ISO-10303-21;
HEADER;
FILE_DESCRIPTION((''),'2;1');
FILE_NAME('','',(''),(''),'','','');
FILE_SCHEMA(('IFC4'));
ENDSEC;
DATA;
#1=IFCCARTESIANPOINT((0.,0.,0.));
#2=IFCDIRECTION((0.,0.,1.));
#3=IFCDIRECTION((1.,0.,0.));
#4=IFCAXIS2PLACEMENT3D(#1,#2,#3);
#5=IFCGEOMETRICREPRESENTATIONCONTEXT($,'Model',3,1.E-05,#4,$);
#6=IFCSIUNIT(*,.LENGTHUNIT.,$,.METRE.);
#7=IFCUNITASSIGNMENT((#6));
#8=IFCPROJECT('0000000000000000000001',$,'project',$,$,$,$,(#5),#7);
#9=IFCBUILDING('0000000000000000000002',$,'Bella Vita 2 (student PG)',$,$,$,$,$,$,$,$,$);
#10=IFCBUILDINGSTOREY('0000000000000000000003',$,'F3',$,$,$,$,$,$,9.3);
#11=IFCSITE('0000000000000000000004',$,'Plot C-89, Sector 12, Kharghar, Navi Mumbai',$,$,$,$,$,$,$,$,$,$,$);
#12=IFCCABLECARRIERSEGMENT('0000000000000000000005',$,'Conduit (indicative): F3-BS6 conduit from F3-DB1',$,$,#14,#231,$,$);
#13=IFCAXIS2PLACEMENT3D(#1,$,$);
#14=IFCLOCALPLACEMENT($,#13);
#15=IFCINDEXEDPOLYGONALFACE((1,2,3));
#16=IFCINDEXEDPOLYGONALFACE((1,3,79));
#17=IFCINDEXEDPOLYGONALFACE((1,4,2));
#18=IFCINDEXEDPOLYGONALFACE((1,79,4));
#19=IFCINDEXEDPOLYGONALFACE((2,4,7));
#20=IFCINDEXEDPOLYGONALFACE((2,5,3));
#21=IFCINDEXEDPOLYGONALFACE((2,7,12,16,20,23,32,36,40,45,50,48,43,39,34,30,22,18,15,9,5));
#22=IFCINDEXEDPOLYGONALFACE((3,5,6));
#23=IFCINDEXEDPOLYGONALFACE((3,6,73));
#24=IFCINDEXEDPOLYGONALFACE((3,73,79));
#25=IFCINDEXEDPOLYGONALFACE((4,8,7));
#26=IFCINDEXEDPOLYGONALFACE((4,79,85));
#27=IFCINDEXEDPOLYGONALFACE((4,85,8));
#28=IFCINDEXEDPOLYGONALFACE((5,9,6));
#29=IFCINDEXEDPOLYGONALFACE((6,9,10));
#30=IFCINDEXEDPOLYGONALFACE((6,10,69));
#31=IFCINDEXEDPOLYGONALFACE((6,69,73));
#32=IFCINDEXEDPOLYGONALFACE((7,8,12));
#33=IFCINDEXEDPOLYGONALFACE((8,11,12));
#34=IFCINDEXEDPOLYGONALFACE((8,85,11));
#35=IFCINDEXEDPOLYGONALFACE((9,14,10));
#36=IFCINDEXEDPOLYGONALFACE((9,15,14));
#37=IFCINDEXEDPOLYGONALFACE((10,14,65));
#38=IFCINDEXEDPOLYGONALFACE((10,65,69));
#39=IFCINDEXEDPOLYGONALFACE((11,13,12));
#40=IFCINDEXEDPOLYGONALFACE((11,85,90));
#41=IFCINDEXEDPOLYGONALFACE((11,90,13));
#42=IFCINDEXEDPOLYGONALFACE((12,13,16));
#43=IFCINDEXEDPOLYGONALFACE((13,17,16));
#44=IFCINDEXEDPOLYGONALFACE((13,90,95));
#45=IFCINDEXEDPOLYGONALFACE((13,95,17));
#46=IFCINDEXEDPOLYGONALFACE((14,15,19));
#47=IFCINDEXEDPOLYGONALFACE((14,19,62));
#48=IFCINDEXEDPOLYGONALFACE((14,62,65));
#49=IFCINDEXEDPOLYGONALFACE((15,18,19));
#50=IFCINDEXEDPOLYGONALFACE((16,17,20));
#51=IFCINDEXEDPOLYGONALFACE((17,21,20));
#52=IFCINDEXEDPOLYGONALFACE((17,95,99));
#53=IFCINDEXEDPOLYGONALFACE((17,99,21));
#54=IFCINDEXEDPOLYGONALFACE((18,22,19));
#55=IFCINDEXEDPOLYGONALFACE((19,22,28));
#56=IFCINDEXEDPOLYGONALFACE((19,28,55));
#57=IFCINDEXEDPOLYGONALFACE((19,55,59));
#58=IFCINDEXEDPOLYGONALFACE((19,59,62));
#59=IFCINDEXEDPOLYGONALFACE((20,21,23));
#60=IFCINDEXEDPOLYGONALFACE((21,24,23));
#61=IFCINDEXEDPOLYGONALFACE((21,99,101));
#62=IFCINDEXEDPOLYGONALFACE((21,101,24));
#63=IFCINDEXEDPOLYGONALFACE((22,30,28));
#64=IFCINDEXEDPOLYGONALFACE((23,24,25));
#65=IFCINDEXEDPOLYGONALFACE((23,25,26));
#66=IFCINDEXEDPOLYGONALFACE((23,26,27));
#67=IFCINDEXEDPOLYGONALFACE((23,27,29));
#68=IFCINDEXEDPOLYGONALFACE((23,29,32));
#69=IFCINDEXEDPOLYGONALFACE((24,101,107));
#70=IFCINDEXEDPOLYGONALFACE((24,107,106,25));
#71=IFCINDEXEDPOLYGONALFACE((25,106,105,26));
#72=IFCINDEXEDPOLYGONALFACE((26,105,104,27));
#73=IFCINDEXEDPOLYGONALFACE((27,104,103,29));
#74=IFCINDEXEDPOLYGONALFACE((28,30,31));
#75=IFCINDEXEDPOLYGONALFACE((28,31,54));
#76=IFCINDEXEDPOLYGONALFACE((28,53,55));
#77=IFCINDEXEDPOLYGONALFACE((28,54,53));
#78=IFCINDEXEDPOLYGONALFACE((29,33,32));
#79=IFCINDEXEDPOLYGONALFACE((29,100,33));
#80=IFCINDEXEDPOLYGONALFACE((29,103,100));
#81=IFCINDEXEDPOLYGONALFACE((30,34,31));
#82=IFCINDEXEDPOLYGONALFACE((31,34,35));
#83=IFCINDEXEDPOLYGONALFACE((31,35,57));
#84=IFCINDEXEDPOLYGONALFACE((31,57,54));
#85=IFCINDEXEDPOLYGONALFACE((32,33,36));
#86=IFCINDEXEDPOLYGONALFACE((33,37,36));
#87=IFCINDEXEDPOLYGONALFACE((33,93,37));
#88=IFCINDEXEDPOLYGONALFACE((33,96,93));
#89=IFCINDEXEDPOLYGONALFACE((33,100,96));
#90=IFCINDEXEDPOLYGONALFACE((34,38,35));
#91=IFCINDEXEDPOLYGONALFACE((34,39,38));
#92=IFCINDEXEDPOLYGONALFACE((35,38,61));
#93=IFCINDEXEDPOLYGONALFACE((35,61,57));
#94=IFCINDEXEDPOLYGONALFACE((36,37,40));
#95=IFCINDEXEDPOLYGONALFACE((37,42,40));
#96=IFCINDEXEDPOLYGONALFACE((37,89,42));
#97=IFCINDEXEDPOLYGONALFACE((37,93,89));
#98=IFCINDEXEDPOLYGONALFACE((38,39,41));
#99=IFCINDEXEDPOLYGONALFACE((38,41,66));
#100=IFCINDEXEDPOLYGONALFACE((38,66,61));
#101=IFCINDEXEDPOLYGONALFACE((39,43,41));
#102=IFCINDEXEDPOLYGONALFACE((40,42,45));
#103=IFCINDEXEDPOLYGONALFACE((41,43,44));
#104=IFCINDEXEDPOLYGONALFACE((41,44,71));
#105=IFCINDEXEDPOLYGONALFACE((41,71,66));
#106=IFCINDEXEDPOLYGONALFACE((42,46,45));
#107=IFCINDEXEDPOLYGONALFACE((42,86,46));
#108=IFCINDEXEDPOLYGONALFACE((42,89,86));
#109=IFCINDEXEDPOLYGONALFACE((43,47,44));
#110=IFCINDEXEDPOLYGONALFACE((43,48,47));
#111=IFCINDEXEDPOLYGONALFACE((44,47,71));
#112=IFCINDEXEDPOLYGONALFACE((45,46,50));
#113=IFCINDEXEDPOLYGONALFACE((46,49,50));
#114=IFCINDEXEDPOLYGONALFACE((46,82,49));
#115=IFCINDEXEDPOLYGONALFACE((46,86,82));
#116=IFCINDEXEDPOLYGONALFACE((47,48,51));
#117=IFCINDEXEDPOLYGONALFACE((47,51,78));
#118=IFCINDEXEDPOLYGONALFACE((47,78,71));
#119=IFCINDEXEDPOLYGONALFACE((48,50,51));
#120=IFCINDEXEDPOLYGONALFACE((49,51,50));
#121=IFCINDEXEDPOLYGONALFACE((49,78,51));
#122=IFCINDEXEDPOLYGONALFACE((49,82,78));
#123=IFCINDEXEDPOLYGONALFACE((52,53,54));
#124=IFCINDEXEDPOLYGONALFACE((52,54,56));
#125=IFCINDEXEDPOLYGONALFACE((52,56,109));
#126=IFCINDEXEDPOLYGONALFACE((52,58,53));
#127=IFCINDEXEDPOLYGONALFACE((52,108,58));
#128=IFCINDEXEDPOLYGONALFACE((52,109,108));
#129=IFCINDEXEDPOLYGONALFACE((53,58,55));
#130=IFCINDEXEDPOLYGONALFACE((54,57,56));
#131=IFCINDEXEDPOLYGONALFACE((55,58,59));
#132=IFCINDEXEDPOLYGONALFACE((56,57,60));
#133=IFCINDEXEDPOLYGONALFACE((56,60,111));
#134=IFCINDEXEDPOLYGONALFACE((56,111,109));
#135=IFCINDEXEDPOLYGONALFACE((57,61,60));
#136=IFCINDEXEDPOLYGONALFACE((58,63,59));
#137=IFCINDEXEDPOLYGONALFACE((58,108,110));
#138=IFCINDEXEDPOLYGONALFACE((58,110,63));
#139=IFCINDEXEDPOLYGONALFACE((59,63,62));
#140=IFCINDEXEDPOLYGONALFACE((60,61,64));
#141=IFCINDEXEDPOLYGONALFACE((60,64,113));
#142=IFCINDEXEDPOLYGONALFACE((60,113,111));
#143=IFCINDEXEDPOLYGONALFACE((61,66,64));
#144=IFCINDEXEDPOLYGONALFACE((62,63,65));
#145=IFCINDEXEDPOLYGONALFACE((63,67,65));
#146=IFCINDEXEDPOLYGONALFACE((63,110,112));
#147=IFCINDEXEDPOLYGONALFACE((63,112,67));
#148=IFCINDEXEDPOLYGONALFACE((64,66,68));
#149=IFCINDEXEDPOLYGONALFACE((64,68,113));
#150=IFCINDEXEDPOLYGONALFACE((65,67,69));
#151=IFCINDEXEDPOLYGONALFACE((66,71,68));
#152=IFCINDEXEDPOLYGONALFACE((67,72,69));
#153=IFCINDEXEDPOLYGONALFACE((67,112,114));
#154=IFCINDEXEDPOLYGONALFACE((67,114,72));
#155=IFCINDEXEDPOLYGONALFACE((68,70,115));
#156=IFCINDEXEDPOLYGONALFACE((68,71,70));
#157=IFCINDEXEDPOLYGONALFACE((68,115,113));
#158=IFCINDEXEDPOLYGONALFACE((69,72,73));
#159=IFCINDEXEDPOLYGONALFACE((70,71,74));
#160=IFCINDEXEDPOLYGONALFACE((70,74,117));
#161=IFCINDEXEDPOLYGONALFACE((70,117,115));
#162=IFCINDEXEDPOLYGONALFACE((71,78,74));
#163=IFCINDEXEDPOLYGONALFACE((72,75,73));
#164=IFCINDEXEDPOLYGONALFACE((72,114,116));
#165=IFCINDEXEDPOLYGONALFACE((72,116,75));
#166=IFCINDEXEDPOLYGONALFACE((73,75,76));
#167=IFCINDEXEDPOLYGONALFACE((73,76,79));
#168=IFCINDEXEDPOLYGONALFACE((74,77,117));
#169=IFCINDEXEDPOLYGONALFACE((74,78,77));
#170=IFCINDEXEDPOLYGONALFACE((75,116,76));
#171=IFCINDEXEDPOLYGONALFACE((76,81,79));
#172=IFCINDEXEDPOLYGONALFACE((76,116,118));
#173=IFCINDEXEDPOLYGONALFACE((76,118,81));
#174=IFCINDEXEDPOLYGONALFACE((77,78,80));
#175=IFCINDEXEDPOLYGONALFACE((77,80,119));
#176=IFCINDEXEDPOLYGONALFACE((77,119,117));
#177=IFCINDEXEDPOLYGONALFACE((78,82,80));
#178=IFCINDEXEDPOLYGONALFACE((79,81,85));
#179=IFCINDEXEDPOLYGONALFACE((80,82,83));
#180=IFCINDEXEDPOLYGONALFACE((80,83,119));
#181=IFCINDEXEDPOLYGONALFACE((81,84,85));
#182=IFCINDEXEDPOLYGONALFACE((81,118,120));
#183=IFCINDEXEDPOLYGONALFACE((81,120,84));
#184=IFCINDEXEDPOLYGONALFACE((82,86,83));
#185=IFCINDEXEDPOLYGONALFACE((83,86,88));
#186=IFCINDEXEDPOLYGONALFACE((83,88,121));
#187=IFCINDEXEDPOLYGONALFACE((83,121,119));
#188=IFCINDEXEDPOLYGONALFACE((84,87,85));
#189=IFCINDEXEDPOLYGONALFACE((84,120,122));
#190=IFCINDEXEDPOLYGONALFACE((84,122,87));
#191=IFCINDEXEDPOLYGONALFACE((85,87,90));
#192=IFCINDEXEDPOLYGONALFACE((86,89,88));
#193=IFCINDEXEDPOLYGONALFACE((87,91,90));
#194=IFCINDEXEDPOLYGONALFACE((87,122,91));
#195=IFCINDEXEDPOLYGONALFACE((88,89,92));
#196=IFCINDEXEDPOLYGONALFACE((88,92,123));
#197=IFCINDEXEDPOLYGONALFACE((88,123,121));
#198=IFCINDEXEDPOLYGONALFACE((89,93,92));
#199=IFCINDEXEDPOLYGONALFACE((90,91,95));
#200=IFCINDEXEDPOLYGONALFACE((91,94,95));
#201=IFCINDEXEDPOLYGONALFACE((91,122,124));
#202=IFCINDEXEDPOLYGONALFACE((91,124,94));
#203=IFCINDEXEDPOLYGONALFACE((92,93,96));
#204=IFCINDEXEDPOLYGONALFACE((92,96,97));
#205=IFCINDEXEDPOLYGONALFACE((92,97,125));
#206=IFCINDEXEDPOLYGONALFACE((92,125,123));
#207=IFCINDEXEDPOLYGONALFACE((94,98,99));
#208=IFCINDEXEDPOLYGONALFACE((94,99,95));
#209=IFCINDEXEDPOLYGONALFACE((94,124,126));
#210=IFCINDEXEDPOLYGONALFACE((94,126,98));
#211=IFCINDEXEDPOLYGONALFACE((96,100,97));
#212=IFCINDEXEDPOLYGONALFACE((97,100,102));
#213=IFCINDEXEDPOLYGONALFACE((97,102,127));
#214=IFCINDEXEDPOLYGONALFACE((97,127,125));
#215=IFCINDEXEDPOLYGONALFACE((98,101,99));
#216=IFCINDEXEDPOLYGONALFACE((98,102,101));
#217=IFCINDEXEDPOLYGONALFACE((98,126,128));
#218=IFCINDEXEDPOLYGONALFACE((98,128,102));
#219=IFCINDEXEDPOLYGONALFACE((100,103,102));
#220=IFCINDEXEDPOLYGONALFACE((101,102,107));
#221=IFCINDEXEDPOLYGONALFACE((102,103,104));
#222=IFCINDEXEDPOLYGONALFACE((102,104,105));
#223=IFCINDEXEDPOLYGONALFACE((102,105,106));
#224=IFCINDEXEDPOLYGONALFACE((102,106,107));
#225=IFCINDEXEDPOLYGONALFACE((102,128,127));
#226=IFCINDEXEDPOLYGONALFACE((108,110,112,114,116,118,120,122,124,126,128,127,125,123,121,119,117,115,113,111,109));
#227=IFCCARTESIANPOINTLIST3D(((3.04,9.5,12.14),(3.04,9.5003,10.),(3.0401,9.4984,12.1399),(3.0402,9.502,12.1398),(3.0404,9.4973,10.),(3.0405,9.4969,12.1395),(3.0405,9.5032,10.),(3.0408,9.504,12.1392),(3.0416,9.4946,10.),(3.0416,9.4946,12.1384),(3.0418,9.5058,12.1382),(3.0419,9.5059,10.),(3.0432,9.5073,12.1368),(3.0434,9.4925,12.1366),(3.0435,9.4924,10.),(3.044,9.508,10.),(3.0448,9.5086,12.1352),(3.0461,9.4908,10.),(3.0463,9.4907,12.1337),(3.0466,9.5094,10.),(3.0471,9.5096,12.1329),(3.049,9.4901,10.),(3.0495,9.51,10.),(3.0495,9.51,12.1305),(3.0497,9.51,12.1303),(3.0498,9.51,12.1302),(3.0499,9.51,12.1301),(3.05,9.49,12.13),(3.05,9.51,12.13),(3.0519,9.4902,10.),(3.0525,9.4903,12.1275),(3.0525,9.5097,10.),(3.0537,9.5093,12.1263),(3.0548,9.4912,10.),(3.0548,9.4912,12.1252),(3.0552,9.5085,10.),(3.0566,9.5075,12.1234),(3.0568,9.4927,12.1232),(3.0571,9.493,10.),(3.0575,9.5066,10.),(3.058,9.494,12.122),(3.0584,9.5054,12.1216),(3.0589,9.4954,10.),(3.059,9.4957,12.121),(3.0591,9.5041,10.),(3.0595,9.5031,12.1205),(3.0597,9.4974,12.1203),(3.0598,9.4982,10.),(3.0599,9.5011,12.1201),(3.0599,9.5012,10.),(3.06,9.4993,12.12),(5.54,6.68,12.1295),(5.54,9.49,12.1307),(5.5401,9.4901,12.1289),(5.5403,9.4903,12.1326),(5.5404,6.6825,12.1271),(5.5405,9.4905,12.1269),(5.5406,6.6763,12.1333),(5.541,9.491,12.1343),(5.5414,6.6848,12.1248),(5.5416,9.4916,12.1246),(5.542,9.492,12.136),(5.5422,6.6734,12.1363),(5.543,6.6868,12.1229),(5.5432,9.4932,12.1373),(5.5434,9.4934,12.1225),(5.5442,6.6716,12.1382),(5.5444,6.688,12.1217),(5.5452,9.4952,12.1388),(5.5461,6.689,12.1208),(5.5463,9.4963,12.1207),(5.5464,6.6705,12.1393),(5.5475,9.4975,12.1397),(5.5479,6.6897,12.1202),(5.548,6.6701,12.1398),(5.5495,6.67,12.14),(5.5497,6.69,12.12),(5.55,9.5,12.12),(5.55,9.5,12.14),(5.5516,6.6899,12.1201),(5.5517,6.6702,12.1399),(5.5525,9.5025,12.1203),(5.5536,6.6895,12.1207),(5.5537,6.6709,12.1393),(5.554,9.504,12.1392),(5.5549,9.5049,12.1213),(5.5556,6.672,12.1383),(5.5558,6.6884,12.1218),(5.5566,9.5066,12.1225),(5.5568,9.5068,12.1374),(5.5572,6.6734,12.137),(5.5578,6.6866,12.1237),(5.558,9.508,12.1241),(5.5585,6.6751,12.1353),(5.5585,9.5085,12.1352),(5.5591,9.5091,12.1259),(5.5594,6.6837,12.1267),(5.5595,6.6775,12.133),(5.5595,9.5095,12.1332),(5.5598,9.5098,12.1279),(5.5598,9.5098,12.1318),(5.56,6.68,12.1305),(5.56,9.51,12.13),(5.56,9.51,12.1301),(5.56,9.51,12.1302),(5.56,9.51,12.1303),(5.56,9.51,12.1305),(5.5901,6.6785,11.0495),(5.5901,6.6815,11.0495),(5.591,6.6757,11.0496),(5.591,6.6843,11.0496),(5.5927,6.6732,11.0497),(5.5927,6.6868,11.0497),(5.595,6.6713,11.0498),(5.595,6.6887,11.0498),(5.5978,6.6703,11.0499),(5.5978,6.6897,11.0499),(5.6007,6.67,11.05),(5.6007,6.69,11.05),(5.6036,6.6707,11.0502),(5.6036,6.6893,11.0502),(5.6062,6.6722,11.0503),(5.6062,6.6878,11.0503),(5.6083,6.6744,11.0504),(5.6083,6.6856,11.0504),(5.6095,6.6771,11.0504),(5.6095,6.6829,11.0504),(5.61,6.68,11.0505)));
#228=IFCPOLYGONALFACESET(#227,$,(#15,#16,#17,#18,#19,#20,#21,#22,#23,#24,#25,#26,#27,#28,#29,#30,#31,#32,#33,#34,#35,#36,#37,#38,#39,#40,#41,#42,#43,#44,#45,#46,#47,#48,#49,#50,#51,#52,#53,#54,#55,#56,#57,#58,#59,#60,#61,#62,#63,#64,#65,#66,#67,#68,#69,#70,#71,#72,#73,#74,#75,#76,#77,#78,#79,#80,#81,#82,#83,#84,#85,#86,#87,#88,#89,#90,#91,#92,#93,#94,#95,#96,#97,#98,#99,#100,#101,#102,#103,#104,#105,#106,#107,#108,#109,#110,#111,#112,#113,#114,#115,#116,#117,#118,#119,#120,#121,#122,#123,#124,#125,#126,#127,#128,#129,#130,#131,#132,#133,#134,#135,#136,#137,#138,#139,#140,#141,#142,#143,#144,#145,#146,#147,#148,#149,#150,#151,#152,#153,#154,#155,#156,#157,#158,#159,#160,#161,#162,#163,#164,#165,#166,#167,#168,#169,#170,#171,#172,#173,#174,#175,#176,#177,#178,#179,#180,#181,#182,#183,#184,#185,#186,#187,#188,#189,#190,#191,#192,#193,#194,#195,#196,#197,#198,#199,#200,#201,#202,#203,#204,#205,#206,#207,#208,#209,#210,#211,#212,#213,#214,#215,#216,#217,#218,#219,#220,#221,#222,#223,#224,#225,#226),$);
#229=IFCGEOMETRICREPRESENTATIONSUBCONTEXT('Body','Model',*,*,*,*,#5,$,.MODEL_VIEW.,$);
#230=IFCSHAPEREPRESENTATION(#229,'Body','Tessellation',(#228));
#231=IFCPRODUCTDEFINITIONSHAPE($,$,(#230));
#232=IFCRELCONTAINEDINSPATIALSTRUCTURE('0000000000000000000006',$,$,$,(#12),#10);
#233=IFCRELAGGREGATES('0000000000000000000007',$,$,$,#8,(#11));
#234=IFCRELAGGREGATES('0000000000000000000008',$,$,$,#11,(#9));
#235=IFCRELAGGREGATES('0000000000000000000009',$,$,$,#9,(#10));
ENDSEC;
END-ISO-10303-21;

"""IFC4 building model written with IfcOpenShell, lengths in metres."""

from ifc_helpers import new_model, entity, si_unit, origin, origin_with_axes, place, context, subcontext, project, spatial, element, save


model = new_model("IFC4")

# Units and contexts
model_context = context("Model", 3, precision=1e-05, world=origin_with_axes())
body_context = subcontext(model_context, "Body", "Model", "MODEL_VIEW")
ifc_project = project(units=[si_unit("LENGTHUNIT", "METRE")], contexts=[model_context])

# Site, building, storey
site = spatial("IfcSite", under=ifc_project, Name="Plot C-89, Sector 12, Kharghar, Navi Mumbai")
building = spatial("IfcBuilding", under=site, Name="Bella Vita 2 (student PG)")
storey = spatial("IfcBuildingStorey", under=building, Name="F3", Elevation=9.3)

# Cable carrier segment
cable_carrier_segment_1_placement = place(None, origin())
element("IfcCableCarrierSegment", 1, at=cable_carrier_segment_1_placement, inside=storey, Name="Conduit (indicative): F3-BS6 conduit from F3-DB1", context=body_context, shape_type="AdvancedSweptSolid", body=[
    entity("IfcSweptDiskSolid", entity("IfcPolyline", [entity("IfcCartesianPoint", [5.6, 6.68, 11.05]), entity("IfcCartesianPoint", [5.55, 6.68, 12.13]), entity("IfcCartesianPoint", [5.55, 9.5, 12.13]), entity("IfcCartesianPoint", [3.05, 9.5, 12.13]), entity("IfcCartesianPoint", [3.05, 9.5, 10.0])]), 0.01),
])

save(model, "model.ifc")
